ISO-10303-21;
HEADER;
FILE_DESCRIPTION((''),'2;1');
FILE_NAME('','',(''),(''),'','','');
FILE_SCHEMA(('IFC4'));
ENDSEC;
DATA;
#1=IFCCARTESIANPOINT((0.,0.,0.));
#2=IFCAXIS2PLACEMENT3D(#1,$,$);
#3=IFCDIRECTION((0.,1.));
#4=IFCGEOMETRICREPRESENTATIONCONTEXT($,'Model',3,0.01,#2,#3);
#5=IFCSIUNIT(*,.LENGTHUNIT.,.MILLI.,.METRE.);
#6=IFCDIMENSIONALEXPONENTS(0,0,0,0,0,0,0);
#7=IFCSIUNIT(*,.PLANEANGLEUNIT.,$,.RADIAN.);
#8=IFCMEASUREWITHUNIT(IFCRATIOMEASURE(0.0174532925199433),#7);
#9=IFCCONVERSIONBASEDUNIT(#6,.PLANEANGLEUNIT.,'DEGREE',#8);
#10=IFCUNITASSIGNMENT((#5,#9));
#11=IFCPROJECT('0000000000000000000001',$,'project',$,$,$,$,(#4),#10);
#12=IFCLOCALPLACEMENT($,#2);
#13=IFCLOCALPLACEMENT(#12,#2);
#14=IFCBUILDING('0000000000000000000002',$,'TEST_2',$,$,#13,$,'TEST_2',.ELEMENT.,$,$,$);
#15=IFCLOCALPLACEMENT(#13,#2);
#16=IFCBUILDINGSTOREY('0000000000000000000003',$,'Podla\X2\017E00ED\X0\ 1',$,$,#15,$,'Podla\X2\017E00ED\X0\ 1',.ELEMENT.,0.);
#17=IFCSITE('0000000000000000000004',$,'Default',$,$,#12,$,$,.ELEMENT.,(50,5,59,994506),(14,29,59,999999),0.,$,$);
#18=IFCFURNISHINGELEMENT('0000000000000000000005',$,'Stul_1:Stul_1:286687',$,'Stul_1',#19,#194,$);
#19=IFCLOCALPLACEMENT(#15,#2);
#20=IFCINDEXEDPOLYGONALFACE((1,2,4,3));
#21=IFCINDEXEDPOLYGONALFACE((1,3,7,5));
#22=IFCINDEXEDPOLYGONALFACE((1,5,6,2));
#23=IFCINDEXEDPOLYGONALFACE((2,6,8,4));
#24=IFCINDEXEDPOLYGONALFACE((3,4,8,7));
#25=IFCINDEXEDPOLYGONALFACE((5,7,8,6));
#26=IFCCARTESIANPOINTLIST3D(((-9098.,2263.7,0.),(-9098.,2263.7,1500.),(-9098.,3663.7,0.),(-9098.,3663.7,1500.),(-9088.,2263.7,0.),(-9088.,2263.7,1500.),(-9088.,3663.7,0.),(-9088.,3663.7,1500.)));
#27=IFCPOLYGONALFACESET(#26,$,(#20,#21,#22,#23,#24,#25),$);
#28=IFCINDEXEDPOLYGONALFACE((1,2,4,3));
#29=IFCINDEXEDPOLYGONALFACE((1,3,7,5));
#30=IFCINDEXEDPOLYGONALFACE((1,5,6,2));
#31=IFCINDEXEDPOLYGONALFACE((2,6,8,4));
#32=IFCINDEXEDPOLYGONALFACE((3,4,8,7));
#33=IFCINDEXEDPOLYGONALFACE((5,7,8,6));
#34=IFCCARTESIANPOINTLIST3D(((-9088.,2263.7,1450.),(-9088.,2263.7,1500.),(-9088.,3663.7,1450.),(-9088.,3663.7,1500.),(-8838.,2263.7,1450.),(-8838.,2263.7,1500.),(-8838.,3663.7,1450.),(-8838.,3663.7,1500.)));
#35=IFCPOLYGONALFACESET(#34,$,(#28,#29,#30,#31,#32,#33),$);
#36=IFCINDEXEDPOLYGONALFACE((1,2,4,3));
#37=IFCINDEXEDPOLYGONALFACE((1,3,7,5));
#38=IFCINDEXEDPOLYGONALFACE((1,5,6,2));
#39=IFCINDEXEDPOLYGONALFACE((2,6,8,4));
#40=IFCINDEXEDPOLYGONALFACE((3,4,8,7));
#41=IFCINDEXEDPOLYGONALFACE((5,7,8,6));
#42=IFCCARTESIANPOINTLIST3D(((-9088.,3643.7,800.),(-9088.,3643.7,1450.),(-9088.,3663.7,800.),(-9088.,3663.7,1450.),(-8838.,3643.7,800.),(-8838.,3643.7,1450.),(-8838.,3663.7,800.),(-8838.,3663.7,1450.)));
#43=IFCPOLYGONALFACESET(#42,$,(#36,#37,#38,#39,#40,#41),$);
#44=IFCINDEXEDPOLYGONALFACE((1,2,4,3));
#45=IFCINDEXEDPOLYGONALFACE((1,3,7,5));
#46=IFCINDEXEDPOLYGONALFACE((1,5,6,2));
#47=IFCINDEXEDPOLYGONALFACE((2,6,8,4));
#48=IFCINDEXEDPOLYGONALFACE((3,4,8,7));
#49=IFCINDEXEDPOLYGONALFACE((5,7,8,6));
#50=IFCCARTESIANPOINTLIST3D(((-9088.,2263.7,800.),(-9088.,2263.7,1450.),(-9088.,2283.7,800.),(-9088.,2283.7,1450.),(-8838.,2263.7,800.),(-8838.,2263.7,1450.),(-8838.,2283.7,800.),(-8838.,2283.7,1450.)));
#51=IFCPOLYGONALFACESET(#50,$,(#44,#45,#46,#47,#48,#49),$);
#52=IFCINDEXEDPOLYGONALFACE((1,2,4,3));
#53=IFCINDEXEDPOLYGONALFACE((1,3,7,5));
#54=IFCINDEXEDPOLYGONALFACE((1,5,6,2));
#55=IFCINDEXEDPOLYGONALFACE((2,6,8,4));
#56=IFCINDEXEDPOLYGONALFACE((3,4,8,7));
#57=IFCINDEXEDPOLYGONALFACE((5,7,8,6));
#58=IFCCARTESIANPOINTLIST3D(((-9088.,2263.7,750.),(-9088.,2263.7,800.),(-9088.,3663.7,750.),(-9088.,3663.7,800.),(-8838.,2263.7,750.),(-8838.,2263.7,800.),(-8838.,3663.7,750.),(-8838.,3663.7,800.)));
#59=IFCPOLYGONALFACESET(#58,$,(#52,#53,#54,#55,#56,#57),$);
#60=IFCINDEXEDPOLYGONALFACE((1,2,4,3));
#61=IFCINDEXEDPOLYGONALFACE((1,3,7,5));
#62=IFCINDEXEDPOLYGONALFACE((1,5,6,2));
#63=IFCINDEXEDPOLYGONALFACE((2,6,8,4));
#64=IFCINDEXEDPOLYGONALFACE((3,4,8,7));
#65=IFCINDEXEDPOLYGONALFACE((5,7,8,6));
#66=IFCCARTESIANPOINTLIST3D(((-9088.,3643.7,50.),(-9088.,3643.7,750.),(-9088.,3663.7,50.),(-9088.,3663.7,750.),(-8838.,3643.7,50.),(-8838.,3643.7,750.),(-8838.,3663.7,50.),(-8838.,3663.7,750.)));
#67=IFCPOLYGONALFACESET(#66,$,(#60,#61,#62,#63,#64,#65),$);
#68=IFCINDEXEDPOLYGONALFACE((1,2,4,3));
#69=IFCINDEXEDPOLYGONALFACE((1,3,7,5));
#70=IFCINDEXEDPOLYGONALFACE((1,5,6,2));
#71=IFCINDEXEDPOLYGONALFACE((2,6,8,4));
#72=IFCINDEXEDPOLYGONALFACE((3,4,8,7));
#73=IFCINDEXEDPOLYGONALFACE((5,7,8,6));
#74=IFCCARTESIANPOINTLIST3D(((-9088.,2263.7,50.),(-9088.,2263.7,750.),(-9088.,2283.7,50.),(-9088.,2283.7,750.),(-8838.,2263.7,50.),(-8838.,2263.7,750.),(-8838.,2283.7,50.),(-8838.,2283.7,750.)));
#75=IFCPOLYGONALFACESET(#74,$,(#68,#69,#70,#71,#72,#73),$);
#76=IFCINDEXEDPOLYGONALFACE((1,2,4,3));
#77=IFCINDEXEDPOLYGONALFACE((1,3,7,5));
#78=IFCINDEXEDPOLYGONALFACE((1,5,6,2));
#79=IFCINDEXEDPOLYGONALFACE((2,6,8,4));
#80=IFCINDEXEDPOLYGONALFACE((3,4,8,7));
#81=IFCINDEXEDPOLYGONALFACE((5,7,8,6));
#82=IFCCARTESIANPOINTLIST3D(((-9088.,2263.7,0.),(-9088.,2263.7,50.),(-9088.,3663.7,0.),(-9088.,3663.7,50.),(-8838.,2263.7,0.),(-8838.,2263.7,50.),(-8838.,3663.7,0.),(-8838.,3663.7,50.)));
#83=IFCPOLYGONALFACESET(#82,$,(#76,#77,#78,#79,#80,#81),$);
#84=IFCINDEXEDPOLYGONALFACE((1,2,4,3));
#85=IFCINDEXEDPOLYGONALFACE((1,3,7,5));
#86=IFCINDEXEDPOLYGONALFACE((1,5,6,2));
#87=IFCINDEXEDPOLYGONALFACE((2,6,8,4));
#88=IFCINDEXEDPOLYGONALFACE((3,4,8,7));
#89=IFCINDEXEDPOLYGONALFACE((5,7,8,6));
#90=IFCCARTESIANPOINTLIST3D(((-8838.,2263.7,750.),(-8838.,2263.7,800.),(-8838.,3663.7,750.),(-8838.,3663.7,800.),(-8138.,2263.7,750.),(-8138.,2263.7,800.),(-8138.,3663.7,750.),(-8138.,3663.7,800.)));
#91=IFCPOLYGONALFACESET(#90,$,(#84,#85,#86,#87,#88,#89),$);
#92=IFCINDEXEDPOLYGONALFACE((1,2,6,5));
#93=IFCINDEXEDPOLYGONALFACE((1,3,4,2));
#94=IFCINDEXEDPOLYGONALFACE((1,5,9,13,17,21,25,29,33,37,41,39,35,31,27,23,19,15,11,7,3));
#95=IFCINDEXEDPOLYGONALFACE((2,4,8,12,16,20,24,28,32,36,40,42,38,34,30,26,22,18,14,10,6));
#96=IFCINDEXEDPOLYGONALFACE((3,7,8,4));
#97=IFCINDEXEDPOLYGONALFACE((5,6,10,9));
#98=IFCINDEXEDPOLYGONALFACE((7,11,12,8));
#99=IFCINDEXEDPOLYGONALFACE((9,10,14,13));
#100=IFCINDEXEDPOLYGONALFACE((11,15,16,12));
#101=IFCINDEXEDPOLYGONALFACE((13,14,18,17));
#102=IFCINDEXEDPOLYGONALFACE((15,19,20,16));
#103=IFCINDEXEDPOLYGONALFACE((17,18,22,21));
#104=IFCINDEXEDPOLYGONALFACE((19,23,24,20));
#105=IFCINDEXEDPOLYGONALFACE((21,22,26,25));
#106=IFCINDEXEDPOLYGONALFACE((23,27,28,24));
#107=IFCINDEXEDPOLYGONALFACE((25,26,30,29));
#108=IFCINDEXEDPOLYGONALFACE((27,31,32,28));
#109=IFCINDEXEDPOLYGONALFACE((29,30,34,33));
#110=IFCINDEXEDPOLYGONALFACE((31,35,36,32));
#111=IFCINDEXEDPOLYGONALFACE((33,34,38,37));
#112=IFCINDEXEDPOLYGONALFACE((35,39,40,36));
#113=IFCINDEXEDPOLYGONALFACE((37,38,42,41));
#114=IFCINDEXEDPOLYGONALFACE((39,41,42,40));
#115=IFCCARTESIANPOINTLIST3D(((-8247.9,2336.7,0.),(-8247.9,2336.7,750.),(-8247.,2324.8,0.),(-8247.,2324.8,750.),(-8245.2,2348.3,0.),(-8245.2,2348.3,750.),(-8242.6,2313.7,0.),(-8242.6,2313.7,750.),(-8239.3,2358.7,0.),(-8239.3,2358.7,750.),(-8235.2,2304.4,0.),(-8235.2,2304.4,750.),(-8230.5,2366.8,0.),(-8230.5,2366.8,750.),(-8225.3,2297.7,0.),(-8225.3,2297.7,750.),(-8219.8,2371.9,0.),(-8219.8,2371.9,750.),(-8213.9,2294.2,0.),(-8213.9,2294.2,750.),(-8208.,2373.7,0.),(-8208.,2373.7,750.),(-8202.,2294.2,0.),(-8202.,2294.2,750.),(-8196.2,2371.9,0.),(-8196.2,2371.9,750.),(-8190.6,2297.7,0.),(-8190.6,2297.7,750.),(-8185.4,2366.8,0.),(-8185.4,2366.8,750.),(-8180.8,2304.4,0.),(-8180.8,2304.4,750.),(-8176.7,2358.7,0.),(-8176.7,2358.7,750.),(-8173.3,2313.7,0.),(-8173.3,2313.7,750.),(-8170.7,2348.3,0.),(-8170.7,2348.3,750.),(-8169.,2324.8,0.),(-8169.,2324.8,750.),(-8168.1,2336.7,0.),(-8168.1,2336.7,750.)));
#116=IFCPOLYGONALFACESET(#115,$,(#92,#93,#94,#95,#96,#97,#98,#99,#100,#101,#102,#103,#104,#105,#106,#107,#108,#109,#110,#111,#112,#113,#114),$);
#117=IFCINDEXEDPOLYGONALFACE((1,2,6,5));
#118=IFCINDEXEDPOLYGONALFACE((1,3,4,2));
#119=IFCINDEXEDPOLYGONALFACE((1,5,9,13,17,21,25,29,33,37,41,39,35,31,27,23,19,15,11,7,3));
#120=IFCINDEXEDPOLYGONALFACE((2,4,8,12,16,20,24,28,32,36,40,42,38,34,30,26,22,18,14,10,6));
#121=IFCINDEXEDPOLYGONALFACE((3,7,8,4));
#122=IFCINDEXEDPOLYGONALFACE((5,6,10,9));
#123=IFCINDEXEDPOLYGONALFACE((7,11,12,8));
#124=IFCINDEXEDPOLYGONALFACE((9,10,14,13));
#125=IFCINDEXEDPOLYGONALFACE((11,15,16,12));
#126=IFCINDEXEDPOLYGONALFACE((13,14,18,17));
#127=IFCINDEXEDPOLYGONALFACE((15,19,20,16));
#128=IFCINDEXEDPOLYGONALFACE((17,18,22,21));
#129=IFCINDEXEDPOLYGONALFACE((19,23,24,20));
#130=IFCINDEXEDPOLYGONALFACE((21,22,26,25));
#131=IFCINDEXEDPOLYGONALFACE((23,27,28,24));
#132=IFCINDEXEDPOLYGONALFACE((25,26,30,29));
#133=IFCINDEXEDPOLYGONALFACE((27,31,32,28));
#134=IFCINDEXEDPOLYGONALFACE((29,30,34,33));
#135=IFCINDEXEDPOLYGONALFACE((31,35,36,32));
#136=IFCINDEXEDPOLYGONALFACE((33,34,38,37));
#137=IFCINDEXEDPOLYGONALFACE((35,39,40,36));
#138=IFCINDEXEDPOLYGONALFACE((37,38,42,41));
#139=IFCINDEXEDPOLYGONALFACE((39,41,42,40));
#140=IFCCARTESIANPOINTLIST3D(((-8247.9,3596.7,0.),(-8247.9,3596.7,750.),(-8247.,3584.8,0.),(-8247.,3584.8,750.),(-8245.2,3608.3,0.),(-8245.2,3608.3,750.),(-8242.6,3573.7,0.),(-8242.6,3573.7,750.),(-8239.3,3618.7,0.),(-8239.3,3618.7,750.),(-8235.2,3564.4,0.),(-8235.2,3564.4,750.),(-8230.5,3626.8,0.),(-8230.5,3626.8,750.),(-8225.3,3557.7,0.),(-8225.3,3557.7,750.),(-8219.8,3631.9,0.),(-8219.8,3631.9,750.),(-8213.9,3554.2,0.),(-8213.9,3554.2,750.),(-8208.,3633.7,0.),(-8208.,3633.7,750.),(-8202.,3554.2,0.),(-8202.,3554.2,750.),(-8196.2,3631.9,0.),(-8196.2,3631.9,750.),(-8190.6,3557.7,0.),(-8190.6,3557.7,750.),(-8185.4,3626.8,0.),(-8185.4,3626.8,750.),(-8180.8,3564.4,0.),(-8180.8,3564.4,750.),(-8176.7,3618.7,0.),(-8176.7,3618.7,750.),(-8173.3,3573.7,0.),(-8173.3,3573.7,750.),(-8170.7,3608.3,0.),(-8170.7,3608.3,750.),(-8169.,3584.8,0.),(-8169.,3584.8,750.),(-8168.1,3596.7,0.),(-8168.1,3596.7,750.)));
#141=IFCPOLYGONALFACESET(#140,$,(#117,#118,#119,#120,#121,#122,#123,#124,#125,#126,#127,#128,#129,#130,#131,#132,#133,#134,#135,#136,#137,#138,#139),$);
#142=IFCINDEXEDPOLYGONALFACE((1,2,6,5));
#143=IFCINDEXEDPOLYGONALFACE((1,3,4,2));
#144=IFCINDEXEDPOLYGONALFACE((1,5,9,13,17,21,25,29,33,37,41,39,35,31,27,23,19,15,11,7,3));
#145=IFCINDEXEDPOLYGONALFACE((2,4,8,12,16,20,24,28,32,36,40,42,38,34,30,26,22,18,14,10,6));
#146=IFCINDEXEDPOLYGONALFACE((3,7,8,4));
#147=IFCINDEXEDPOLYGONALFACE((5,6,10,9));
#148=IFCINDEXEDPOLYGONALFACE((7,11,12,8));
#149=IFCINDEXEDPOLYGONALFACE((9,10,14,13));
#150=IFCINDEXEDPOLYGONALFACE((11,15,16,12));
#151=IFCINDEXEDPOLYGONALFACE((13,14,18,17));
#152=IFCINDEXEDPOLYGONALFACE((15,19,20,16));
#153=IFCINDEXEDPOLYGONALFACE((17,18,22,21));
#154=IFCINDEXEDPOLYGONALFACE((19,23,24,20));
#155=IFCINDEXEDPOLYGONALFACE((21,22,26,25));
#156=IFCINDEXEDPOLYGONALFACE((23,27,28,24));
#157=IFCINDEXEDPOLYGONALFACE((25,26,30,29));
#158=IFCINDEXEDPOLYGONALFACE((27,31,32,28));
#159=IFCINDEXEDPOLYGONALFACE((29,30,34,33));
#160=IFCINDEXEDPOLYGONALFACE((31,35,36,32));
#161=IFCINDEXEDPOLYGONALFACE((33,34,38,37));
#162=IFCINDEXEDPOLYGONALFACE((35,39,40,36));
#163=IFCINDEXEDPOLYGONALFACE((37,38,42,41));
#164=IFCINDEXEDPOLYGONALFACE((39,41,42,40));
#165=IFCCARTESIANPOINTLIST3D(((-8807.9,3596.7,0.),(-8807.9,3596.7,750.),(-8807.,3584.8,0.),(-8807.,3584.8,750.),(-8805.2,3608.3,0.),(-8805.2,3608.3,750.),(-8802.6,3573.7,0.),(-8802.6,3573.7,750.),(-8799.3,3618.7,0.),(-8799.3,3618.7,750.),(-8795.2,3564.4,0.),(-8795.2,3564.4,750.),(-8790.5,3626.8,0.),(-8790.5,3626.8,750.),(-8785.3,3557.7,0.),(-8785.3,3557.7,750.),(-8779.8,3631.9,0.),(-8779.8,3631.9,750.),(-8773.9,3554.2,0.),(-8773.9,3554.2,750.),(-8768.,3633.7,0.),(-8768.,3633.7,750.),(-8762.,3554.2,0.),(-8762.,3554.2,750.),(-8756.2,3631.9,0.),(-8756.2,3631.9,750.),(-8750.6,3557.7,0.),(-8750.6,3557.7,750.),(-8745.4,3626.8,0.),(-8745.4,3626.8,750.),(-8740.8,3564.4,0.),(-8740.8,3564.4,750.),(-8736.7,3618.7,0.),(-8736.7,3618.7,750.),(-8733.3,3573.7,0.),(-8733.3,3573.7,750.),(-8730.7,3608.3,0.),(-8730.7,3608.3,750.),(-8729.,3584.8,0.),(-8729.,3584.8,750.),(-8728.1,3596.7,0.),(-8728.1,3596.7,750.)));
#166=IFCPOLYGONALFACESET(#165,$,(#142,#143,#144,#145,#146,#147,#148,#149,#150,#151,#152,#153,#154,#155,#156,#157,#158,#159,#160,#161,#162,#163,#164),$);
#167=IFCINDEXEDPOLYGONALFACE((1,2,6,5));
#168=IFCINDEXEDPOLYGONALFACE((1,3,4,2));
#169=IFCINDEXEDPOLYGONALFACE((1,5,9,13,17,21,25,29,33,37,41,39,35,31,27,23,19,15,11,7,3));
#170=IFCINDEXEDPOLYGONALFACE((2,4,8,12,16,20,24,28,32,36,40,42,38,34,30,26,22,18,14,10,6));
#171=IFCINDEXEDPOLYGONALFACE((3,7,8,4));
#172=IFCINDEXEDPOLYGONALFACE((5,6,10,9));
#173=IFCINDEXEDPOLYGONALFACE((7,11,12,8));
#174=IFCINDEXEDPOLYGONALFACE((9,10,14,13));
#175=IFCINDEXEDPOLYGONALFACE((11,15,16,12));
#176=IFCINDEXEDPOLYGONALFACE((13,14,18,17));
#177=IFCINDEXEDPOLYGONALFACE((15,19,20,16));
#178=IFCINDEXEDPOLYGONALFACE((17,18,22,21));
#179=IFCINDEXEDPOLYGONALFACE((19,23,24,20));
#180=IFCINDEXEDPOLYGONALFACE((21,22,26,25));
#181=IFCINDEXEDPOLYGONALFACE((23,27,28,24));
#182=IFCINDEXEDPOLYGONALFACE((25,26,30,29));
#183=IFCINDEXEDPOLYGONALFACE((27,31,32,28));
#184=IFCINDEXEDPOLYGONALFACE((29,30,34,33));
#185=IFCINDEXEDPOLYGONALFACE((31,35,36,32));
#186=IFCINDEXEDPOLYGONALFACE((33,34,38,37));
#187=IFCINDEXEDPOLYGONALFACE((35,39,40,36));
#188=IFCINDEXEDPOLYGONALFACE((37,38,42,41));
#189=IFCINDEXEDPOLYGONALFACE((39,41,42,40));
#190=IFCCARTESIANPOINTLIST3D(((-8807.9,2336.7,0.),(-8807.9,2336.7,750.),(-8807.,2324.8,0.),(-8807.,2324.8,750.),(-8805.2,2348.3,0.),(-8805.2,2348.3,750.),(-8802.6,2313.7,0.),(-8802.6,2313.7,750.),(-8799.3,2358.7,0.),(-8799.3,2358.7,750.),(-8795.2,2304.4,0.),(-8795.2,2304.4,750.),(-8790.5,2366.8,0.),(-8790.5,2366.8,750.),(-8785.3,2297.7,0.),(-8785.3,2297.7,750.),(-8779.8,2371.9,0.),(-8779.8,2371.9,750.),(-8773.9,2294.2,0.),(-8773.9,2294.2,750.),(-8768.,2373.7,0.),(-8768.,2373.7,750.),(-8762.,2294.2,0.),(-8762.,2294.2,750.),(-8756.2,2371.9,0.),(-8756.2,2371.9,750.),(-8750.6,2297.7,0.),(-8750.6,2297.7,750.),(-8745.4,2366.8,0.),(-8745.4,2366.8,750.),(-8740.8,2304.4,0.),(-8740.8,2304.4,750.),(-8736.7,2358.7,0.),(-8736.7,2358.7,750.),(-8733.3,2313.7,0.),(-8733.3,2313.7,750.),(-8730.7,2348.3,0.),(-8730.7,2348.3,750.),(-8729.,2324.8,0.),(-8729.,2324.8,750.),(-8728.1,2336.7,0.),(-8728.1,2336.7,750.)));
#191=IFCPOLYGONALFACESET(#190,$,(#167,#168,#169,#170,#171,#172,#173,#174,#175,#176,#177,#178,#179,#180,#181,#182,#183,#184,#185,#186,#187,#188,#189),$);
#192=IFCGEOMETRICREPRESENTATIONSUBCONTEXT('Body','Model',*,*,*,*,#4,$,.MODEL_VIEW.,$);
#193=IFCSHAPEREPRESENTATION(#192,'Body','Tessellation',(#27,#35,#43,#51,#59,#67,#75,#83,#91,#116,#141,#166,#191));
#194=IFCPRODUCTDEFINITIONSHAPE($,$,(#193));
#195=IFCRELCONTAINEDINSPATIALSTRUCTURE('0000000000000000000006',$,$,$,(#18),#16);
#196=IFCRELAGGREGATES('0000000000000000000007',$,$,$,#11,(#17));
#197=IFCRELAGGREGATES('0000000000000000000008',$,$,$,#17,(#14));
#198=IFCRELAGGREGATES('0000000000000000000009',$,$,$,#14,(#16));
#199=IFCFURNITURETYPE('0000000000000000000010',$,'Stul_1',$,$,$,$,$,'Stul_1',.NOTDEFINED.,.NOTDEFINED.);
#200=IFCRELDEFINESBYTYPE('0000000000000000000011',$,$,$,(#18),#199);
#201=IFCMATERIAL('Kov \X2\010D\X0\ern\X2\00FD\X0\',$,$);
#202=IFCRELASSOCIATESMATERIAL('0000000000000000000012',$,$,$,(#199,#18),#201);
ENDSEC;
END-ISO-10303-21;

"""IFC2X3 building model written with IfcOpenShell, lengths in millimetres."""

from ifc_helpers import new_model, entity, si_unit, converted_unit, direction, frame, frame_2d, origin, origin_2d_with_axis, place, context, subcontext, project, spatial, rectangle, circle, extrude, source, transform, mapped, material, type_object, type_shapes, element, save


model = new_model("IFC2X3")

# Units and contexts
model_context = context("Model", 3, precision=0.01, world=origin(), true_north=direction((0.0, 1.0)))
body_context = subcontext(model_context, "Body", "Model", "MODEL_VIEW")
ifc_project = project(units=[si_unit("LENGTHUNIT", "METRE", prefix="MILLI"), converted_unit("PLANEANGLEUNIT", "DEGREE", entity("IfcRatioMeasure", 0.0174532925199433), si_unit("PLANEANGLEUNIT", "RADIAN"), dimensions=[0, 0, 0, 0, 0, 0, 0])], contexts=[model_context])

# Site, building, storey
site_placement = place(None, origin())
site = spatial("IfcSite", under=ifc_project, at=site_placement, Name="Default", CompositionType="ELEMENT", RefLatitude=(50, 5, 59, 994506), RefLongitude=(14, 29, 59, 999999), RefElevation=0.0)
building_placement = place(site_placement, origin())
building = spatial("IfcBuilding", under=site, at=building_placement, Name="TEST_2", LongName="TEST_2", CompositionType="ELEMENT")
storey_placement = place(building_placement, origin())
storey = spatial("IfcBuildingStorey", under=building, at=storey_placement, Name="Podlaží 1", LongName="Podlaží 1", CompositionType="ELEMENT", Elevation=0.0)

# Furnishing element
ifc_material_1 = material(Name="Kov černý")
furniture_type = type_object("IfcFurnitureType", Name="Stul_1", ElementType="Stul_1", material=ifc_material_1)
shared_shape_1 = source(origin(), body_context, "Body", "SweptSolid", [
    extrude(rectangle(XDim=1400.0, YDim=10.0, at=origin_2d_with_axis()), frame((0.0, 605.0, 0.0), z_axis=(0.0, 0.0, 1.0), x_axis=(-1.0, 0.0, 0.0)), (0.0, 0.0, 1.0), 1500.0),
    extrude(rectangle(XDim=1400.0, YDim=250.0, at=frame_2d((0.0, 0.0), x_axis=(1.0, 0.0))), frame((0.0, 475.0, 1450.0), z_axis=(0.0, 0.0, 1.0), x_axis=(-1.0, 0.0, 0.0)), (0.0, 0.0, 1.0), 50.0),
    extrude(rectangle(XDim=20.0, YDim=250.0, at=origin_2d_with_axis()), frame((690.0, 475.0, 800.0), z_axis=(0.0, 0.0, 1.0), x_axis=(-1.0, 0.0, 0.0)), (0.0, 0.0, 1.0), 650.0),
    extrude(rectangle(XDim=20.0, YDim=250.0, at=frame_2d((0.0, 0.0), x_axis=(1.0, 0.0))), frame((-690.0, 475.0, 800.0), z_axis=(0.0, 0.0, 1.0), x_axis=(-1.0, 0.0, 0.0)), (0.0, 0.0, 1.0), 650.0),
    extrude(rectangle(XDim=1400.0, YDim=250.0, at=origin_2d_with_axis()), frame((0.0, 475.0, 750.0), z_axis=(0.0, 0.0, 1.0), x_axis=(-1.0, 0.0, 0.0)), (0.0, 0.0, 1.0), 50.0),
    extrude(rectangle(XDim=20.0, YDim=250.0, at=origin_2d_with_axis()), frame((690.0, 475.0, 50.0), z_axis=(0.0, 0.0, 1.0), x_axis=(-1.0, 0.0, 0.0)), (0.0, 0.0, 1.0), 700.0),
    extrude(rectangle(XDim=20.0, YDim=250.0, at=frame_2d((0.0, 0.0), x_axis=(1.0, 0.0))), frame((-690.0, 475.0, 50.0), z_axis=(0.0, 0.0, 1.0), x_axis=(-1.0, 0.0, 0.0)), (0.0, 0.0, 1.0), 700.0),
    extrude(rectangle(XDim=1400.0, YDim=250.0, at=origin_2d_with_axis()), frame((0.0, 475.0, 0.0), z_axis=(0.0, 0.0, 1.0), x_axis=(-1.0, 0.0, 0.0)), (0.0, 0.0, 1.0), 50.0),
    extrude(rectangle(XDim=1400.0, YDim=700.0, at=origin_2d_with_axis()), frame((0.0, 0.0, 750.0), z_axis=(0.0, 0.0, 1.0), x_axis=(-1.0, 0.0, 0.0)), (0.0, 0.0, 1.0), 50.0),
    extrude(circle(Radius=40.0, at=frame_2d((0.0, 0.0), x_axis=(1.0, 0.0))), frame((-630.0, -280.0, 0.0)), (0.0, 0.0, 1.0), 750.0),
    extrude(circle(Radius=40.0, at=frame_2d((0.0, 0.0), x_axis=(1.0, 0.0))), frame((630.0, -280.0, 0.0)), (0.0, 0.0, 1.0), 750.0),
    extrude(circle(Radius=40.0, at=frame_2d((0.0, 0.0), x_axis=(1.0, 0.0))), frame((630.0, 280.0, 0.0)), (0.0, 0.0, 1.0), 750.0),
    extrude(circle(Radius=40.0, at=frame_2d((0.0, 0.0), x_axis=(1.0, 0.0))), frame((-630.0, 280.0, 0.0)), (0.0, 0.0, 1.0), 750.0),
])
type_shapes(furniture_type, [shared_shape_1])
for number, where, z_axis, x_axis, name in (
    (1, (-8488.0, 2963.7, 0.0), (0.0, 0.0, 1.0), (0.0, 1.0, 0.0), "Stul_1:Stul_1:286687"),
):
    element("IfcFurnishingElement", number, at=place(storey_placement, frame(where, z_axis=z_axis, x_axis=x_axis)), inside=storey, type_object=furniture_type, material=ifc_material_1, Name=name, ObjectType="Stul_1", context=body_context, shape_type="MappedRepresentation", body=[
        mapped(shared_shape_1, transform((0.0, 0.0, 0.0), scale=1.0)),
    ])

save(model, "model.ifc")
